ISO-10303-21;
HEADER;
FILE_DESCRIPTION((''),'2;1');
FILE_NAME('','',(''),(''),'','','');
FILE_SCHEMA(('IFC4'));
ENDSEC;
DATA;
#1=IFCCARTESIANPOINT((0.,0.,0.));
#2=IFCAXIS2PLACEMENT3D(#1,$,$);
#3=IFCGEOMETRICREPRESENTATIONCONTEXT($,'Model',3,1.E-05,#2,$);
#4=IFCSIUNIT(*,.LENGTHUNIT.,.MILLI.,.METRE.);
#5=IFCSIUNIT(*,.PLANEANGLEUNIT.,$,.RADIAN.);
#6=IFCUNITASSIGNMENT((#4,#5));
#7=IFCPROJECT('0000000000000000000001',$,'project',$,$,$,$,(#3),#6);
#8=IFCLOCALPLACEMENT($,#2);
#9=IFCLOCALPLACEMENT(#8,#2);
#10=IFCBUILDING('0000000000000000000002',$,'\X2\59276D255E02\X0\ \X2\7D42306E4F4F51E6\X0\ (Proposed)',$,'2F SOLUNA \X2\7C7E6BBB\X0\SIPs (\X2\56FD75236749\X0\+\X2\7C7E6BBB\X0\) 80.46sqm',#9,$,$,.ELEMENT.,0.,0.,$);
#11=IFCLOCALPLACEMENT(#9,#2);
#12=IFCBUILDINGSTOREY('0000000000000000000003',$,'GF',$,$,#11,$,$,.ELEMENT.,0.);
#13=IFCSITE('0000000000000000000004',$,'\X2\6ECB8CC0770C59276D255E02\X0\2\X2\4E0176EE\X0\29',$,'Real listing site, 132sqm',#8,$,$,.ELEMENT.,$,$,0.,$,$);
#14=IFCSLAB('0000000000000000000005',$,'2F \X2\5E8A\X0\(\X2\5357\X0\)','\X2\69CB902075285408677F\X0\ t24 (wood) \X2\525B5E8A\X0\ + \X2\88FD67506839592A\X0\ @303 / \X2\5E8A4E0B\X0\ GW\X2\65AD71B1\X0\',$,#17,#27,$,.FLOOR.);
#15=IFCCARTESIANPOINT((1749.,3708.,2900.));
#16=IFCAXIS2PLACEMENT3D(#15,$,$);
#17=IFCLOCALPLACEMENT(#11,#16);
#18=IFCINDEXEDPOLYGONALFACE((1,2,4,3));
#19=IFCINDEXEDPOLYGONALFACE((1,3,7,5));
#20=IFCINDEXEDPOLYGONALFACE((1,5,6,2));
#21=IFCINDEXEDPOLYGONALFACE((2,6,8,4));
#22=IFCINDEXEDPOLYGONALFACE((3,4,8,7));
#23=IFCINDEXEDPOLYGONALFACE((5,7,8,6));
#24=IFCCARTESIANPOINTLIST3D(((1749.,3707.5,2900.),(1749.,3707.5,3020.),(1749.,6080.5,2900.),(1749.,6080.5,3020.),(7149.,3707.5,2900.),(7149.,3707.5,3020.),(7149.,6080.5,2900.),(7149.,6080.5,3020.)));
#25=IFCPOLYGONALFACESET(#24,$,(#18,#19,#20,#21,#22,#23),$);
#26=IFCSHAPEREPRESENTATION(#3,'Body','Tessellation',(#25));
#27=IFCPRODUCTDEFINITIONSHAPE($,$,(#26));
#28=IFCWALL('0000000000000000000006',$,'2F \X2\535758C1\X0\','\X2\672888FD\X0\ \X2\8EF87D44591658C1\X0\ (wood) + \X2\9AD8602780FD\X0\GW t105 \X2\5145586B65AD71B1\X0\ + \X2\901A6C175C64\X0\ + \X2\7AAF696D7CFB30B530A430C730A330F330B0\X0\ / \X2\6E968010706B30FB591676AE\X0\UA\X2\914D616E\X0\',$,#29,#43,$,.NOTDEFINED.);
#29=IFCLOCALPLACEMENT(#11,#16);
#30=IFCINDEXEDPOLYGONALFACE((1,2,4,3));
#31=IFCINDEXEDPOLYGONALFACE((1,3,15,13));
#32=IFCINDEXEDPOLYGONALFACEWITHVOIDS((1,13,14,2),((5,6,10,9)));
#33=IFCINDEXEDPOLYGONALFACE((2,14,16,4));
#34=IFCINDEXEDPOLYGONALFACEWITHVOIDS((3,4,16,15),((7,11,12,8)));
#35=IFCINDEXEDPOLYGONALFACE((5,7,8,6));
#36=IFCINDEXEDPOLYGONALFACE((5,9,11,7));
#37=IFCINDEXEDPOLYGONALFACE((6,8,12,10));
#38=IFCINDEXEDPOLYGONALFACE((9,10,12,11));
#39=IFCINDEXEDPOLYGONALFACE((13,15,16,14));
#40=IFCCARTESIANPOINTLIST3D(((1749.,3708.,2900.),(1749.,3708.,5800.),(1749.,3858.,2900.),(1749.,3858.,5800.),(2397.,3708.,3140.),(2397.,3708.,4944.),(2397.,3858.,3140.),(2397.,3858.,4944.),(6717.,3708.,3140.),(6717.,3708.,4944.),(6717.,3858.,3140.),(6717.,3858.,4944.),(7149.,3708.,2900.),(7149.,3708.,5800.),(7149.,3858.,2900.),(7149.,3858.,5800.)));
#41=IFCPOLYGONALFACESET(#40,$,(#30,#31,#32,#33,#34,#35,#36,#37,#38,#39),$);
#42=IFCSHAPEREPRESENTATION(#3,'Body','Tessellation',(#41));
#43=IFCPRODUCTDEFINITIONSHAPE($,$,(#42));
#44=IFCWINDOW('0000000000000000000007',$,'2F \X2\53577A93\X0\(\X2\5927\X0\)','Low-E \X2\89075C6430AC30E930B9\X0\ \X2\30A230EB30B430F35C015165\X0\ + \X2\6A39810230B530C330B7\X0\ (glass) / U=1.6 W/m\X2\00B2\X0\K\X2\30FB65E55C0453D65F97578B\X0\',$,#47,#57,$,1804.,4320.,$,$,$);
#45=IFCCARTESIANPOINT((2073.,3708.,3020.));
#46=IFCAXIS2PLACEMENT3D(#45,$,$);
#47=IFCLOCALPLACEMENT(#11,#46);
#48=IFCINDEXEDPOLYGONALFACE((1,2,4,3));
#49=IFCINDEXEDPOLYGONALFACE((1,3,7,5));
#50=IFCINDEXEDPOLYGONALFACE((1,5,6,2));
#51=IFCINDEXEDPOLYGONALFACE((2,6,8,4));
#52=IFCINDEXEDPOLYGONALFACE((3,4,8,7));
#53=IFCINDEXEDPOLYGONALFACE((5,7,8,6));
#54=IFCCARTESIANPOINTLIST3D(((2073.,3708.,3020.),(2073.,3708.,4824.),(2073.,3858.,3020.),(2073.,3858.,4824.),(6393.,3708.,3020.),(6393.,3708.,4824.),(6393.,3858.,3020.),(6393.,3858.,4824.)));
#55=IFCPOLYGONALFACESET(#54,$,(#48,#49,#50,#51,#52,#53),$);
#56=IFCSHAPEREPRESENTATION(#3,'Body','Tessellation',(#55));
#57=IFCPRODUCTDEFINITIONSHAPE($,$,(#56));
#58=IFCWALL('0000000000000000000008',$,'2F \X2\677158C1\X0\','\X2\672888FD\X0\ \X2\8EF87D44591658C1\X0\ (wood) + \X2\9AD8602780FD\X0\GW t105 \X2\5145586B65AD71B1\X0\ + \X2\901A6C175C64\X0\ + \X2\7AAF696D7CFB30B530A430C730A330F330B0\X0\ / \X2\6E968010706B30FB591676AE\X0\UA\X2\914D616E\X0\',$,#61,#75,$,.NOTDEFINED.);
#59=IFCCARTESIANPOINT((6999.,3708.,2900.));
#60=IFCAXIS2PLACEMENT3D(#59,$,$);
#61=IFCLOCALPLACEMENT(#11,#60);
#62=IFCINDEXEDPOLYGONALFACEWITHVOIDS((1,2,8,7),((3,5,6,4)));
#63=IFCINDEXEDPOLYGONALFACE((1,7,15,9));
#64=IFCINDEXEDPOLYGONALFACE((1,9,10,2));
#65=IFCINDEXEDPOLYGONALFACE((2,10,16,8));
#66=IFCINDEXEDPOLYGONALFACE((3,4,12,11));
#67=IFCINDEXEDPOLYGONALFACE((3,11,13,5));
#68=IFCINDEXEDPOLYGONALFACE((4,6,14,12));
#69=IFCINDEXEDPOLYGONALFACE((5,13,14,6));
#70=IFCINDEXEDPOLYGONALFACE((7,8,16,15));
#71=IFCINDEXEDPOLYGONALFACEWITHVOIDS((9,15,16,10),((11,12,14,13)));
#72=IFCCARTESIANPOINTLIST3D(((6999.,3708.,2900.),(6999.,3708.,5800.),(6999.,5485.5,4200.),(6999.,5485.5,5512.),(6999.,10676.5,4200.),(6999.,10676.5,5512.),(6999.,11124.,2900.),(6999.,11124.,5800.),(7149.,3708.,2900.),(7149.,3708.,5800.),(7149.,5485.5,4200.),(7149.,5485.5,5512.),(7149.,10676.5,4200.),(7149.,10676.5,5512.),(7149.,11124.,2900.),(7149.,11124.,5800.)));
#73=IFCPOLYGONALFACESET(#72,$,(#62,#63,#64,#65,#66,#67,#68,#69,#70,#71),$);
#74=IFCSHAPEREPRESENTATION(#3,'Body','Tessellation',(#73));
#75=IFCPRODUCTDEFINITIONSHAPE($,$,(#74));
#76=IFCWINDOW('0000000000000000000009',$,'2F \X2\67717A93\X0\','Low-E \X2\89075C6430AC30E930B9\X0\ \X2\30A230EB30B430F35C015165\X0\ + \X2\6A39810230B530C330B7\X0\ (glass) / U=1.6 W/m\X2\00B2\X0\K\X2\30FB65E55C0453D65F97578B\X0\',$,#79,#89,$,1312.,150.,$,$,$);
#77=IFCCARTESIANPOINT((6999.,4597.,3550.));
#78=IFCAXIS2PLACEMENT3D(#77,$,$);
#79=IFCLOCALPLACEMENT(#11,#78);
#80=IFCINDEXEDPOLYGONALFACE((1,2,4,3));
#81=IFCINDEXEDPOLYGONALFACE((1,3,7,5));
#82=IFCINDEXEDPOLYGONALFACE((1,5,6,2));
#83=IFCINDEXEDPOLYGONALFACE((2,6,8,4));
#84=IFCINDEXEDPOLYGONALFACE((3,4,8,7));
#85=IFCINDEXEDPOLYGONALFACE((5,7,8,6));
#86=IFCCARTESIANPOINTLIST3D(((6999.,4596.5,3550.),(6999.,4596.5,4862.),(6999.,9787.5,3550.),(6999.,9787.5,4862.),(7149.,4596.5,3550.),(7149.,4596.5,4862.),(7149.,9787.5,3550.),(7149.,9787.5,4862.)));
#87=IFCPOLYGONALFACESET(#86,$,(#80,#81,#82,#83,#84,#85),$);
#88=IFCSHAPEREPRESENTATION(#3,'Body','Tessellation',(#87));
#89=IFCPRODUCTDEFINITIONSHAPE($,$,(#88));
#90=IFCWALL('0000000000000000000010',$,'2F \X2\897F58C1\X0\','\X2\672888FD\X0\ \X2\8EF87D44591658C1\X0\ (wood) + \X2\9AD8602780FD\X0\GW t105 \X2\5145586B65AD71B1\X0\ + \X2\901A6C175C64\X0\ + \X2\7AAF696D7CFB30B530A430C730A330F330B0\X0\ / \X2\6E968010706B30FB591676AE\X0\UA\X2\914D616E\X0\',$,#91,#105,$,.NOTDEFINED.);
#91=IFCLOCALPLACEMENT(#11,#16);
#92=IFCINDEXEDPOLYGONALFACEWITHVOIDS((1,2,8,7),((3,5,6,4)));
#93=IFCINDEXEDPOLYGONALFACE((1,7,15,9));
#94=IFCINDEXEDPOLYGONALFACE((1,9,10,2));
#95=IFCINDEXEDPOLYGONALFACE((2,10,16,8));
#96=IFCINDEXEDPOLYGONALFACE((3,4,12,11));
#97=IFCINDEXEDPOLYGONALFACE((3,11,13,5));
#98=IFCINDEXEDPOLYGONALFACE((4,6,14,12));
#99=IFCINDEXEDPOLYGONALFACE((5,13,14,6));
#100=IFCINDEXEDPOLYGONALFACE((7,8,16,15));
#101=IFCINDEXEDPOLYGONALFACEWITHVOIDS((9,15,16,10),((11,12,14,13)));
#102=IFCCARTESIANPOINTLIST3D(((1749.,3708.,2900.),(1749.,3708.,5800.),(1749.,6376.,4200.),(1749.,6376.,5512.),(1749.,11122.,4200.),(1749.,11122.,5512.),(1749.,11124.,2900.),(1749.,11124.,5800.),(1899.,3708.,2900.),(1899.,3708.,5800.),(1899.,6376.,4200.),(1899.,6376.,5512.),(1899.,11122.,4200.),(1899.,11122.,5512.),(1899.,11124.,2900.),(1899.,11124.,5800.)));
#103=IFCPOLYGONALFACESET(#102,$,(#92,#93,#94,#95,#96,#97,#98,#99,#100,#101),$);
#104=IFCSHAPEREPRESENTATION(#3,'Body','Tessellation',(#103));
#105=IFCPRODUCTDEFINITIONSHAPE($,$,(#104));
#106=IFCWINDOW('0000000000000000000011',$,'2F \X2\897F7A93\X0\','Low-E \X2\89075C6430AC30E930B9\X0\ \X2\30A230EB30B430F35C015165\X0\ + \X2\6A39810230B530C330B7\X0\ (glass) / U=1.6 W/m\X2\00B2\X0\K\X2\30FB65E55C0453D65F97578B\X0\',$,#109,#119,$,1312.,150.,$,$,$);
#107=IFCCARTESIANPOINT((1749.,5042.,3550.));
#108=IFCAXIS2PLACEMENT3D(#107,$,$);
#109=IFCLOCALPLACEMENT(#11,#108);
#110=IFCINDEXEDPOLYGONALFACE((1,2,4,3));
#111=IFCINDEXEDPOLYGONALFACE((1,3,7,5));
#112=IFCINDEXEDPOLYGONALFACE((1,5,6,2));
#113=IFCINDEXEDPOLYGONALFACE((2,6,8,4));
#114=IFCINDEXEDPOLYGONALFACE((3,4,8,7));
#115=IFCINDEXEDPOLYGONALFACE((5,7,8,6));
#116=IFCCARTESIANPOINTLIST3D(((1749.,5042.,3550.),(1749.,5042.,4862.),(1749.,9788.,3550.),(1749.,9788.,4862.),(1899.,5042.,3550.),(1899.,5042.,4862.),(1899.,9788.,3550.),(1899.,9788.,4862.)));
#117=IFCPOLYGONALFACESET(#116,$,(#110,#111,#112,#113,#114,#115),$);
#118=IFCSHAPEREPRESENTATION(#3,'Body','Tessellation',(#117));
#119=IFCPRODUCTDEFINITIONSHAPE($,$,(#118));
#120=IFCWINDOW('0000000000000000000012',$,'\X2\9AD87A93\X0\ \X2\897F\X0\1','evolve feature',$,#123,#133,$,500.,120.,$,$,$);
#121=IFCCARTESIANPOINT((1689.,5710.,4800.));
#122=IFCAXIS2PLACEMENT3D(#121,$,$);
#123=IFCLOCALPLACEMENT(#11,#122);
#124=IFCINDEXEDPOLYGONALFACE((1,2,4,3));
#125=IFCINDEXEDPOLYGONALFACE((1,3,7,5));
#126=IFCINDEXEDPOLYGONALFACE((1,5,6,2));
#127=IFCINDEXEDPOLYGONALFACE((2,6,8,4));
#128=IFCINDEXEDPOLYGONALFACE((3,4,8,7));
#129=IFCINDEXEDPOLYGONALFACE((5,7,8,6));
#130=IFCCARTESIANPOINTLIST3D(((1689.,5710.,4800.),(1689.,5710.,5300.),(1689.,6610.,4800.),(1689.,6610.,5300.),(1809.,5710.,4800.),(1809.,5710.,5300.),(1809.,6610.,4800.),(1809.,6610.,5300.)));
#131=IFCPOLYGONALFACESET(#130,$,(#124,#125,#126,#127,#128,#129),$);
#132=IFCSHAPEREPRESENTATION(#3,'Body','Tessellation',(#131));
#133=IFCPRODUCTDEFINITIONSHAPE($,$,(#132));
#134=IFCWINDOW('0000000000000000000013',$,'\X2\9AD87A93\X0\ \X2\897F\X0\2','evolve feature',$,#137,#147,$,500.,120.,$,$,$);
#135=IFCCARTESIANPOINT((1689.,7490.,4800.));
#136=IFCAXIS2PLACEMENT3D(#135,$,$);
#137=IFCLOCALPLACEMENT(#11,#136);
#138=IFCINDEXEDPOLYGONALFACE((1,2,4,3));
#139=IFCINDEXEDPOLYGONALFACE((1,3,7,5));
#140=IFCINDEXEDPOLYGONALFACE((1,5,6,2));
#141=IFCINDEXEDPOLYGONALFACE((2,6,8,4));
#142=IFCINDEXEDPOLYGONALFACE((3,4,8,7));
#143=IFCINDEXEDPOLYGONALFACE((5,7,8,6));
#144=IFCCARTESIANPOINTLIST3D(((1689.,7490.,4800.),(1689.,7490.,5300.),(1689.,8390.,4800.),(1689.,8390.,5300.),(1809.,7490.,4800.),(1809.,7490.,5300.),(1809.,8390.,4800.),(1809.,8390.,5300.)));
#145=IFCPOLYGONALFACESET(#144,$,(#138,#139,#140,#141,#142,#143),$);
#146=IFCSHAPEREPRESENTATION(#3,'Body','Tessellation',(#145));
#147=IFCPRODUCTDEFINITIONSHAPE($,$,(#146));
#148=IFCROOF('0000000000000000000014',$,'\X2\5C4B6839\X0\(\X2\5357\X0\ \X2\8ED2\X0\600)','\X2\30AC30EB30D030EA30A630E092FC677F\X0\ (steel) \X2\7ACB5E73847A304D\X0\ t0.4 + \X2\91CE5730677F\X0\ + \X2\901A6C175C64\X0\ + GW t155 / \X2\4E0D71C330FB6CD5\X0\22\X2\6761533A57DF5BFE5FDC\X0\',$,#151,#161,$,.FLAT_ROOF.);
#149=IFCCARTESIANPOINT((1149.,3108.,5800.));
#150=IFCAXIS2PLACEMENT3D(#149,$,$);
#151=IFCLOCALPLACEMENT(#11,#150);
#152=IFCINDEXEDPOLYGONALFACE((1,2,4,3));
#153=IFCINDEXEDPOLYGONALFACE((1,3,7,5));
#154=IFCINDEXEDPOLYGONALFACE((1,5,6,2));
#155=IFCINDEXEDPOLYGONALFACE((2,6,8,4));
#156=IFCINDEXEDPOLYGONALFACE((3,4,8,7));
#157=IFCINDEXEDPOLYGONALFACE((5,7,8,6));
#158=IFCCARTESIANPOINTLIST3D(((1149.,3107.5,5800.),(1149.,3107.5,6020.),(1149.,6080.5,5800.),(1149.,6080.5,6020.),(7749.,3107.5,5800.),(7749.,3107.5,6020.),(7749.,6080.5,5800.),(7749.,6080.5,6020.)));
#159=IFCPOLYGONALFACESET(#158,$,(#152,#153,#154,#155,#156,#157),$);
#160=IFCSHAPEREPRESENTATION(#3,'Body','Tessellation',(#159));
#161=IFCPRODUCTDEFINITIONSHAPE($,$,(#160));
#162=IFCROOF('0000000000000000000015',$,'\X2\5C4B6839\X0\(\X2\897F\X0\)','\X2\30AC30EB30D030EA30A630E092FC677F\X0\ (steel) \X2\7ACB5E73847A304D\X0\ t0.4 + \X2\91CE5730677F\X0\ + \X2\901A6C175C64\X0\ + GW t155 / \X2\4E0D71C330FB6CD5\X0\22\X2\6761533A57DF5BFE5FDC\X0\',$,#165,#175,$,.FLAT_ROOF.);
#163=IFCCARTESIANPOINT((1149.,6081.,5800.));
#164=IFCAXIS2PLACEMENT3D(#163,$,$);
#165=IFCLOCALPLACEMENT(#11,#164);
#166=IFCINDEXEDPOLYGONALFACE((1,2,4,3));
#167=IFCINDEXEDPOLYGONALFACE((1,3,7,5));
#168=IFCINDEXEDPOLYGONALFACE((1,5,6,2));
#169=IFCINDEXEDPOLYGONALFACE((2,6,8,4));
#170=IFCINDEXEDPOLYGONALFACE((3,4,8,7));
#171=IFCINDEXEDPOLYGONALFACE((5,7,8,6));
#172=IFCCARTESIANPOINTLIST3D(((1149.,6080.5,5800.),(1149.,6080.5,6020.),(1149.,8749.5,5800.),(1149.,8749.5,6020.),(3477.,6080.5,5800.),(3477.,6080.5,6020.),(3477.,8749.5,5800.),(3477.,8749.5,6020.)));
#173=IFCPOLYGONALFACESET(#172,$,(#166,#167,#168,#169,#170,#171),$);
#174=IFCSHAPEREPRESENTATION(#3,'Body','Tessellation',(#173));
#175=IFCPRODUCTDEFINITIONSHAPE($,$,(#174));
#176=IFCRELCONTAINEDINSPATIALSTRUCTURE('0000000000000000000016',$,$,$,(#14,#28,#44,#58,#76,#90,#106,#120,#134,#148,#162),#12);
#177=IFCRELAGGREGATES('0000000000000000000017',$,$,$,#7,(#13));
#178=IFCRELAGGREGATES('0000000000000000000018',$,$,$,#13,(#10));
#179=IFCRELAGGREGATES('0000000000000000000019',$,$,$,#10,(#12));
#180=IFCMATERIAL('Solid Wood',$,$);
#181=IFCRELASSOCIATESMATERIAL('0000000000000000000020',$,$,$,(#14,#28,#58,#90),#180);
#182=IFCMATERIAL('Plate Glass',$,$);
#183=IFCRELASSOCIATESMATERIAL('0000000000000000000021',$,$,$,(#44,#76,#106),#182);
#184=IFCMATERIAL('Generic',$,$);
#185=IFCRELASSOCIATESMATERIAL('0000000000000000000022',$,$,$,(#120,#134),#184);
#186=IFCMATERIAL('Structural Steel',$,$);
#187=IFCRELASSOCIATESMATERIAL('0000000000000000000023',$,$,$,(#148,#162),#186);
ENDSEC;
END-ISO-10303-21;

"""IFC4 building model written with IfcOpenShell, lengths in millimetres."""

from ifc_helpers import new_model, si_unit, frame, frame_2d, origin, place, context, project, spatial, rectangle, extrude, material, element, fill, save


model = new_model("IFC4")

# Units and contexts
model_context = context("Model", 3, precision=1e-05, world=origin())
ifc_project = project(units=[si_unit("LENGTHUNIT", "METRE", prefix="MILLI"), si_unit("PLANEANGLEUNIT", "RADIAN")], contexts=[model_context])

# Site, building, storey
site_placement = place(None, origin())
site = spatial("IfcSite", under=ifc_project, at=site_placement, Name="滋賀県大津市2丁目29", ObjectType="Real listing site, 132sqm", CompositionType="ELEMENT", RefElevation=0.0)
building_placement = place(site_placement, origin())
building = spatial("IfcBuilding", under=site, at=building_placement, Name="大津市 終の住処 (Proposed)", ObjectType="2F SOLUNA 籾殻SIPs (国産杉+籾殻) 80.46sqm", CompositionType="ELEMENT", ElevationOfRefHeight=0.0, ElevationOfTerrain=0.0)
storey_placement = place(building_placement, origin())
storey = spatial("IfcBuildingStorey", under=building, at=storey_placement, Name="GF", CompositionType="ELEMENT", Elevation=0.0)

# Slab
ifc_material_1 = material(Name="Solid Wood")
slab_placement = place(storey_placement, frame((1749.0, 3708.0, 2900.0)))
element("IfcSlab", 1, at=slab_placement, inside=storey, material=ifc_material_1, Name="2F 床(南)", Description="構造用合板 t24 (wood) 剛床 + 製材根太 @303 / 床下 GW断熱", PredefinedType="FLOOR", context=model_context, shape_type="SweptSolid", body=[
    extrude(rectangle(XDim=5400.0, YDim=2373.0, at=frame_2d((2700.0, 1186.0))), frame((1749.0, 3708.0, 2900.0)), (0.0, 0.0, 1.0), 120.0),
])

# Walls, openings, windows
wall_1_placement = place(storey_placement, frame((1749.0, 3708.0, 2900.0)))
wall_1 = element("IfcWall", 2, at=wall_1_placement, inside=storey, material=ifc_material_1, Name="2F 南壁", Description="木製 軸組外壁 (wood) + 高性能GW t105 充填断熱 + 通気層 + 窯業系サイディング / 準耐火・外皮UA配慮", PredefinedType="NOTDEFINED", context=model_context, shape_type="SweptSolid", body=[
    extrude(rectangle(XDim=5400.0, YDim=150.0, at=frame_2d((2700.0, 75.0))), frame((1749.0, 3708.0, 2900.0)), (0.0, 0.0, 1.0), 2900.0),
])
opening_1_placement = place(storey_placement, frame((2073.0, 3708.0, 3020.0)))
opening_1 = element("IfcOpeningElement", 3, at=opening_1_placement, cuts=wall_1, PredefinedType="NOTDEFINED", context=model_context, shape_type="SweptSolid", body=[
    extrude(rectangle(XDim=4320.0, YDim=150.0, at=frame_2d((2160.0, 75.0))), frame((2073.0, 3708.0, 3020.0)), (0.0, 0.0, 1.0), 1804.0),
])
ifc_material_2 = material(Name="Plate Glass")
window_1_placement = place(storey_placement, frame((2073.0, 3708.0, 3020.0)))
window_1 = element("IfcWindow", 4, at=window_1_placement, inside=storey, material=ifc_material_2, Name="2F 南窓(大)", Description="Low-E 複層ガラス アルゴン封入 + 樹脂サッシ (glass) / U=1.6 W/m²K・日射取得型", OverallHeight=1804.0, OverallWidth=4320.0, context=model_context, shape_type="SweptSolid", body=[
    extrude(rectangle(XDim=4320.0, YDim=150.0, at=frame_2d((2160.0, 75.0))), frame((2073.0, 3708.0, 3020.0)), (0.0, 0.0, 1.0), 1804.0),
])
fill(opening_1, window_1)
wall_2_placement = place(storey_placement, frame((6999.0, 3708.0, 2900.0)))
wall_2 = element("IfcWall", 5, at=wall_2_placement, inside=storey, material=ifc_material_1, Name="2F 東壁", Description="木製 軸組外壁 (wood) + 高性能GW t105 充填断熱 + 通気層 + 窯業系サイディング / 準耐火・外皮UA配慮", PredefinedType="NOTDEFINED", context=model_context, shape_type="SweptSolid", body=[
    extrude(rectangle(XDim=150.0, YDim=7416.0, at=frame_2d((75.0, 3708.0))), frame((6999.0, 3708.0, 2900.0)), (0.0, 0.0, 1.0), 2900.0),
])
opening_2_placement = place(storey_placement, frame((6999.0, 4597.0, 3550.0)))
opening_2 = element("IfcOpeningElement", 6, at=opening_2_placement, cuts=wall_2, PredefinedType="NOTDEFINED", context=model_context, shape_type="SweptSolid", body=[
    extrude(rectangle(XDim=150.0, YDim=5191.0, at=frame_2d((75.0, 2595.0))), frame((6999.0, 4597.0, 3550.0)), (0.0, 0.0, 1.0), 1312.0),
])
window_2_placement = place(storey_placement, frame((6999.0, 4597.0, 3550.0)))
window_2 = element("IfcWindow", 7, at=window_2_placement, inside=storey, material=ifc_material_2, Name="2F 東窓", Description="Low-E 複層ガラス アルゴン封入 + 樹脂サッシ (glass) / U=1.6 W/m²K・日射取得型", OverallHeight=1312.0, OverallWidth=150.0, context=model_context, shape_type="SweptSolid", body=[
    extrude(rectangle(XDim=150.0, YDim=5191.0, at=frame_2d((75.0, 2595.0))), frame((6999.0, 4597.0, 3550.0)), (0.0, 0.0, 1.0), 1312.0),
])
fill(opening_2, window_2)

# Wall, openings, windows
wall_3_placement = place(storey_placement, frame((1749.0, 3708.0, 2900.0)))
wall_3 = element("IfcWall", 8, at=wall_3_placement, inside=storey, material=ifc_material_1, Name="2F 西壁", Description="木製 軸組外壁 (wood) + 高性能GW t105 充填断熱 + 通気層 + 窯業系サイディング / 準耐火・外皮UA配慮", PredefinedType="NOTDEFINED", context=model_context, shape_type="SweptSolid", body=[
    extrude(rectangle(XDim=150.0, YDim=7416.0, at=frame_2d((75.0, 3708.0))), frame((1749.0, 3708.0, 2900.0)), (0.0, 0.0, 1.0), 2900.0),
])
opening_3_placement = place(storey_placement, frame((1749.0, 5042.0, 3550.0)))
opening_3 = element("IfcOpeningElement", 9, at=opening_3_placement, cuts=wall_3, PredefinedType="NOTDEFINED", context=model_context, shape_type="SweptSolid", body=[
    extrude(rectangle(XDim=150.0, YDim=4746.0, at=frame_2d((75.0, 2373.0))), frame((1749.0, 5042.0, 3550.0)), (0.0, 0.0, 1.0), 1312.0),
])
opening_4_placement = place(storey_placement, frame((1689.0, 5710.0, 4800.0)))
opening_4 = element("IfcOpeningElement", 10, at=opening_4_placement, cuts=wall_3, PredefinedType="NOTDEFINED", context=model_context, shape_type="SweptSolid", body=[
    extrude(rectangle(XDim=120.0, YDim=900.0, at=frame_2d((60.0, 450.0))), frame((1689.0, 5710.0, 4800.0)), (0.0, 0.0, 1.0), 500.0),
])
opening_5_placement = place(storey_placement, frame((1689.0, 7490.0, 4800.0)))
opening_5 = element("IfcOpeningElement", 11, at=opening_5_placement, cuts=wall_3, PredefinedType="NOTDEFINED", context=model_context, shape_type="SweptSolid", body=[
    extrude(rectangle(XDim=120.0, YDim=900.0, at=frame_2d((60.0, 450.0))), frame((1689.0, 7490.0, 4800.0)), (0.0, 0.0, 1.0), 500.0),
])
window_3_placement = place(storey_placement, frame((1749.0, 5042.0, 3550.0)))
window_3 = element("IfcWindow", 12, at=window_3_placement, inside=storey, material=ifc_material_2, Name="2F 西窓", Description="Low-E 複層ガラス アルゴン封入 + 樹脂サッシ (glass) / U=1.6 W/m²K・日射取得型", OverallHeight=1312.0, OverallWidth=150.0, context=model_context, shape_type="SweptSolid", body=[
    extrude(rectangle(XDim=150.0, YDim=4746.0, at=frame_2d((75.0, 2373.0))), frame((1749.0, 5042.0, 3550.0)), (0.0, 0.0, 1.0), 1312.0),
])
fill(opening_3, window_3)
ifc_material_3 = material(Name="Generic")
window_4_placement = place(storey_placement, frame((1689.0, 5710.0, 4800.0)))
window_4 = element("IfcWindow", 13, at=window_4_placement, inside=storey, material=ifc_material_3, Name="高窓 西1", Description="evolve feature", OverallHeight=500.0, OverallWidth=120.0, context=model_context, shape_type="SweptSolid", body=[
    extrude(rectangle(XDim=120.0, YDim=900.0, at=frame_2d((60.0, 450.0))), frame((1689.0, 5710.0, 4800.0)), (0.0, 0.0, 1.0), 500.0),
])
fill(opening_4, window_4)
window_5_placement = place(storey_placement, frame((1689.0, 7490.0, 4800.0)))
window_5 = element("IfcWindow", 14, at=window_5_placement, inside=storey, material=ifc_material_3, Name="高窓 西2", Description="evolve feature", OverallHeight=500.0, OverallWidth=120.0, context=model_context, shape_type="SweptSolid", body=[
    extrude(rectangle(XDim=120.0, YDim=900.0, at=frame_2d((60.0, 450.0))), frame((1689.0, 7490.0, 4800.0)), (0.0, 0.0, 1.0), 500.0),
])
fill(opening_5, window_5)

# Roofs
ifc_material_4 = material(Name="Structural Steel")
roof_1_placement = place(storey_placement, frame((1149.0, 3108.0, 5800.0)))
element("IfcRoof", 15, at=roof_1_placement, inside=storey, material=ifc_material_4, Name="屋根(南 軒600)", Description="ガルバリウム鋼板 (steel) 立平葺き t0.4 + 野地板 + 通気層 + GW t155 / 不燃・法22条区域対応", PredefinedType="FLAT_ROOF", context=model_context, shape_type="SweptSolid", body=[
    extrude(rectangle(XDim=6600.0, YDim=2973.0, at=frame_2d((3300.0, 1486.0))), frame((1149.0, 3108.0, 5800.0)), (0.0, 0.0, 1.0), 220.0),
])
roof_2_placement = place(storey_placement, frame((1149.0, 6081.0, 5800.0)))
element("IfcRoof", 16, at=roof_2_placement, inside=storey, material=ifc_material_4, Name="屋根(西)", Description="ガルバリウム鋼板 (steel) 立平葺き t0.4 + 野地板 + 通気層 + GW t155 / 不燃・法22条区域対応", PredefinedType="FLAT_ROOF", context=model_context, shape_type="SweptSolid", body=[
    extrude(rectangle(XDim=2328.0, YDim=2669.0, at=frame_2d((1164.0, 1334.0))), frame((1149.0, 6081.0, 5800.0)), (0.0, 0.0, 1.0), 220.0),
])

save(model, "model.ifc")
